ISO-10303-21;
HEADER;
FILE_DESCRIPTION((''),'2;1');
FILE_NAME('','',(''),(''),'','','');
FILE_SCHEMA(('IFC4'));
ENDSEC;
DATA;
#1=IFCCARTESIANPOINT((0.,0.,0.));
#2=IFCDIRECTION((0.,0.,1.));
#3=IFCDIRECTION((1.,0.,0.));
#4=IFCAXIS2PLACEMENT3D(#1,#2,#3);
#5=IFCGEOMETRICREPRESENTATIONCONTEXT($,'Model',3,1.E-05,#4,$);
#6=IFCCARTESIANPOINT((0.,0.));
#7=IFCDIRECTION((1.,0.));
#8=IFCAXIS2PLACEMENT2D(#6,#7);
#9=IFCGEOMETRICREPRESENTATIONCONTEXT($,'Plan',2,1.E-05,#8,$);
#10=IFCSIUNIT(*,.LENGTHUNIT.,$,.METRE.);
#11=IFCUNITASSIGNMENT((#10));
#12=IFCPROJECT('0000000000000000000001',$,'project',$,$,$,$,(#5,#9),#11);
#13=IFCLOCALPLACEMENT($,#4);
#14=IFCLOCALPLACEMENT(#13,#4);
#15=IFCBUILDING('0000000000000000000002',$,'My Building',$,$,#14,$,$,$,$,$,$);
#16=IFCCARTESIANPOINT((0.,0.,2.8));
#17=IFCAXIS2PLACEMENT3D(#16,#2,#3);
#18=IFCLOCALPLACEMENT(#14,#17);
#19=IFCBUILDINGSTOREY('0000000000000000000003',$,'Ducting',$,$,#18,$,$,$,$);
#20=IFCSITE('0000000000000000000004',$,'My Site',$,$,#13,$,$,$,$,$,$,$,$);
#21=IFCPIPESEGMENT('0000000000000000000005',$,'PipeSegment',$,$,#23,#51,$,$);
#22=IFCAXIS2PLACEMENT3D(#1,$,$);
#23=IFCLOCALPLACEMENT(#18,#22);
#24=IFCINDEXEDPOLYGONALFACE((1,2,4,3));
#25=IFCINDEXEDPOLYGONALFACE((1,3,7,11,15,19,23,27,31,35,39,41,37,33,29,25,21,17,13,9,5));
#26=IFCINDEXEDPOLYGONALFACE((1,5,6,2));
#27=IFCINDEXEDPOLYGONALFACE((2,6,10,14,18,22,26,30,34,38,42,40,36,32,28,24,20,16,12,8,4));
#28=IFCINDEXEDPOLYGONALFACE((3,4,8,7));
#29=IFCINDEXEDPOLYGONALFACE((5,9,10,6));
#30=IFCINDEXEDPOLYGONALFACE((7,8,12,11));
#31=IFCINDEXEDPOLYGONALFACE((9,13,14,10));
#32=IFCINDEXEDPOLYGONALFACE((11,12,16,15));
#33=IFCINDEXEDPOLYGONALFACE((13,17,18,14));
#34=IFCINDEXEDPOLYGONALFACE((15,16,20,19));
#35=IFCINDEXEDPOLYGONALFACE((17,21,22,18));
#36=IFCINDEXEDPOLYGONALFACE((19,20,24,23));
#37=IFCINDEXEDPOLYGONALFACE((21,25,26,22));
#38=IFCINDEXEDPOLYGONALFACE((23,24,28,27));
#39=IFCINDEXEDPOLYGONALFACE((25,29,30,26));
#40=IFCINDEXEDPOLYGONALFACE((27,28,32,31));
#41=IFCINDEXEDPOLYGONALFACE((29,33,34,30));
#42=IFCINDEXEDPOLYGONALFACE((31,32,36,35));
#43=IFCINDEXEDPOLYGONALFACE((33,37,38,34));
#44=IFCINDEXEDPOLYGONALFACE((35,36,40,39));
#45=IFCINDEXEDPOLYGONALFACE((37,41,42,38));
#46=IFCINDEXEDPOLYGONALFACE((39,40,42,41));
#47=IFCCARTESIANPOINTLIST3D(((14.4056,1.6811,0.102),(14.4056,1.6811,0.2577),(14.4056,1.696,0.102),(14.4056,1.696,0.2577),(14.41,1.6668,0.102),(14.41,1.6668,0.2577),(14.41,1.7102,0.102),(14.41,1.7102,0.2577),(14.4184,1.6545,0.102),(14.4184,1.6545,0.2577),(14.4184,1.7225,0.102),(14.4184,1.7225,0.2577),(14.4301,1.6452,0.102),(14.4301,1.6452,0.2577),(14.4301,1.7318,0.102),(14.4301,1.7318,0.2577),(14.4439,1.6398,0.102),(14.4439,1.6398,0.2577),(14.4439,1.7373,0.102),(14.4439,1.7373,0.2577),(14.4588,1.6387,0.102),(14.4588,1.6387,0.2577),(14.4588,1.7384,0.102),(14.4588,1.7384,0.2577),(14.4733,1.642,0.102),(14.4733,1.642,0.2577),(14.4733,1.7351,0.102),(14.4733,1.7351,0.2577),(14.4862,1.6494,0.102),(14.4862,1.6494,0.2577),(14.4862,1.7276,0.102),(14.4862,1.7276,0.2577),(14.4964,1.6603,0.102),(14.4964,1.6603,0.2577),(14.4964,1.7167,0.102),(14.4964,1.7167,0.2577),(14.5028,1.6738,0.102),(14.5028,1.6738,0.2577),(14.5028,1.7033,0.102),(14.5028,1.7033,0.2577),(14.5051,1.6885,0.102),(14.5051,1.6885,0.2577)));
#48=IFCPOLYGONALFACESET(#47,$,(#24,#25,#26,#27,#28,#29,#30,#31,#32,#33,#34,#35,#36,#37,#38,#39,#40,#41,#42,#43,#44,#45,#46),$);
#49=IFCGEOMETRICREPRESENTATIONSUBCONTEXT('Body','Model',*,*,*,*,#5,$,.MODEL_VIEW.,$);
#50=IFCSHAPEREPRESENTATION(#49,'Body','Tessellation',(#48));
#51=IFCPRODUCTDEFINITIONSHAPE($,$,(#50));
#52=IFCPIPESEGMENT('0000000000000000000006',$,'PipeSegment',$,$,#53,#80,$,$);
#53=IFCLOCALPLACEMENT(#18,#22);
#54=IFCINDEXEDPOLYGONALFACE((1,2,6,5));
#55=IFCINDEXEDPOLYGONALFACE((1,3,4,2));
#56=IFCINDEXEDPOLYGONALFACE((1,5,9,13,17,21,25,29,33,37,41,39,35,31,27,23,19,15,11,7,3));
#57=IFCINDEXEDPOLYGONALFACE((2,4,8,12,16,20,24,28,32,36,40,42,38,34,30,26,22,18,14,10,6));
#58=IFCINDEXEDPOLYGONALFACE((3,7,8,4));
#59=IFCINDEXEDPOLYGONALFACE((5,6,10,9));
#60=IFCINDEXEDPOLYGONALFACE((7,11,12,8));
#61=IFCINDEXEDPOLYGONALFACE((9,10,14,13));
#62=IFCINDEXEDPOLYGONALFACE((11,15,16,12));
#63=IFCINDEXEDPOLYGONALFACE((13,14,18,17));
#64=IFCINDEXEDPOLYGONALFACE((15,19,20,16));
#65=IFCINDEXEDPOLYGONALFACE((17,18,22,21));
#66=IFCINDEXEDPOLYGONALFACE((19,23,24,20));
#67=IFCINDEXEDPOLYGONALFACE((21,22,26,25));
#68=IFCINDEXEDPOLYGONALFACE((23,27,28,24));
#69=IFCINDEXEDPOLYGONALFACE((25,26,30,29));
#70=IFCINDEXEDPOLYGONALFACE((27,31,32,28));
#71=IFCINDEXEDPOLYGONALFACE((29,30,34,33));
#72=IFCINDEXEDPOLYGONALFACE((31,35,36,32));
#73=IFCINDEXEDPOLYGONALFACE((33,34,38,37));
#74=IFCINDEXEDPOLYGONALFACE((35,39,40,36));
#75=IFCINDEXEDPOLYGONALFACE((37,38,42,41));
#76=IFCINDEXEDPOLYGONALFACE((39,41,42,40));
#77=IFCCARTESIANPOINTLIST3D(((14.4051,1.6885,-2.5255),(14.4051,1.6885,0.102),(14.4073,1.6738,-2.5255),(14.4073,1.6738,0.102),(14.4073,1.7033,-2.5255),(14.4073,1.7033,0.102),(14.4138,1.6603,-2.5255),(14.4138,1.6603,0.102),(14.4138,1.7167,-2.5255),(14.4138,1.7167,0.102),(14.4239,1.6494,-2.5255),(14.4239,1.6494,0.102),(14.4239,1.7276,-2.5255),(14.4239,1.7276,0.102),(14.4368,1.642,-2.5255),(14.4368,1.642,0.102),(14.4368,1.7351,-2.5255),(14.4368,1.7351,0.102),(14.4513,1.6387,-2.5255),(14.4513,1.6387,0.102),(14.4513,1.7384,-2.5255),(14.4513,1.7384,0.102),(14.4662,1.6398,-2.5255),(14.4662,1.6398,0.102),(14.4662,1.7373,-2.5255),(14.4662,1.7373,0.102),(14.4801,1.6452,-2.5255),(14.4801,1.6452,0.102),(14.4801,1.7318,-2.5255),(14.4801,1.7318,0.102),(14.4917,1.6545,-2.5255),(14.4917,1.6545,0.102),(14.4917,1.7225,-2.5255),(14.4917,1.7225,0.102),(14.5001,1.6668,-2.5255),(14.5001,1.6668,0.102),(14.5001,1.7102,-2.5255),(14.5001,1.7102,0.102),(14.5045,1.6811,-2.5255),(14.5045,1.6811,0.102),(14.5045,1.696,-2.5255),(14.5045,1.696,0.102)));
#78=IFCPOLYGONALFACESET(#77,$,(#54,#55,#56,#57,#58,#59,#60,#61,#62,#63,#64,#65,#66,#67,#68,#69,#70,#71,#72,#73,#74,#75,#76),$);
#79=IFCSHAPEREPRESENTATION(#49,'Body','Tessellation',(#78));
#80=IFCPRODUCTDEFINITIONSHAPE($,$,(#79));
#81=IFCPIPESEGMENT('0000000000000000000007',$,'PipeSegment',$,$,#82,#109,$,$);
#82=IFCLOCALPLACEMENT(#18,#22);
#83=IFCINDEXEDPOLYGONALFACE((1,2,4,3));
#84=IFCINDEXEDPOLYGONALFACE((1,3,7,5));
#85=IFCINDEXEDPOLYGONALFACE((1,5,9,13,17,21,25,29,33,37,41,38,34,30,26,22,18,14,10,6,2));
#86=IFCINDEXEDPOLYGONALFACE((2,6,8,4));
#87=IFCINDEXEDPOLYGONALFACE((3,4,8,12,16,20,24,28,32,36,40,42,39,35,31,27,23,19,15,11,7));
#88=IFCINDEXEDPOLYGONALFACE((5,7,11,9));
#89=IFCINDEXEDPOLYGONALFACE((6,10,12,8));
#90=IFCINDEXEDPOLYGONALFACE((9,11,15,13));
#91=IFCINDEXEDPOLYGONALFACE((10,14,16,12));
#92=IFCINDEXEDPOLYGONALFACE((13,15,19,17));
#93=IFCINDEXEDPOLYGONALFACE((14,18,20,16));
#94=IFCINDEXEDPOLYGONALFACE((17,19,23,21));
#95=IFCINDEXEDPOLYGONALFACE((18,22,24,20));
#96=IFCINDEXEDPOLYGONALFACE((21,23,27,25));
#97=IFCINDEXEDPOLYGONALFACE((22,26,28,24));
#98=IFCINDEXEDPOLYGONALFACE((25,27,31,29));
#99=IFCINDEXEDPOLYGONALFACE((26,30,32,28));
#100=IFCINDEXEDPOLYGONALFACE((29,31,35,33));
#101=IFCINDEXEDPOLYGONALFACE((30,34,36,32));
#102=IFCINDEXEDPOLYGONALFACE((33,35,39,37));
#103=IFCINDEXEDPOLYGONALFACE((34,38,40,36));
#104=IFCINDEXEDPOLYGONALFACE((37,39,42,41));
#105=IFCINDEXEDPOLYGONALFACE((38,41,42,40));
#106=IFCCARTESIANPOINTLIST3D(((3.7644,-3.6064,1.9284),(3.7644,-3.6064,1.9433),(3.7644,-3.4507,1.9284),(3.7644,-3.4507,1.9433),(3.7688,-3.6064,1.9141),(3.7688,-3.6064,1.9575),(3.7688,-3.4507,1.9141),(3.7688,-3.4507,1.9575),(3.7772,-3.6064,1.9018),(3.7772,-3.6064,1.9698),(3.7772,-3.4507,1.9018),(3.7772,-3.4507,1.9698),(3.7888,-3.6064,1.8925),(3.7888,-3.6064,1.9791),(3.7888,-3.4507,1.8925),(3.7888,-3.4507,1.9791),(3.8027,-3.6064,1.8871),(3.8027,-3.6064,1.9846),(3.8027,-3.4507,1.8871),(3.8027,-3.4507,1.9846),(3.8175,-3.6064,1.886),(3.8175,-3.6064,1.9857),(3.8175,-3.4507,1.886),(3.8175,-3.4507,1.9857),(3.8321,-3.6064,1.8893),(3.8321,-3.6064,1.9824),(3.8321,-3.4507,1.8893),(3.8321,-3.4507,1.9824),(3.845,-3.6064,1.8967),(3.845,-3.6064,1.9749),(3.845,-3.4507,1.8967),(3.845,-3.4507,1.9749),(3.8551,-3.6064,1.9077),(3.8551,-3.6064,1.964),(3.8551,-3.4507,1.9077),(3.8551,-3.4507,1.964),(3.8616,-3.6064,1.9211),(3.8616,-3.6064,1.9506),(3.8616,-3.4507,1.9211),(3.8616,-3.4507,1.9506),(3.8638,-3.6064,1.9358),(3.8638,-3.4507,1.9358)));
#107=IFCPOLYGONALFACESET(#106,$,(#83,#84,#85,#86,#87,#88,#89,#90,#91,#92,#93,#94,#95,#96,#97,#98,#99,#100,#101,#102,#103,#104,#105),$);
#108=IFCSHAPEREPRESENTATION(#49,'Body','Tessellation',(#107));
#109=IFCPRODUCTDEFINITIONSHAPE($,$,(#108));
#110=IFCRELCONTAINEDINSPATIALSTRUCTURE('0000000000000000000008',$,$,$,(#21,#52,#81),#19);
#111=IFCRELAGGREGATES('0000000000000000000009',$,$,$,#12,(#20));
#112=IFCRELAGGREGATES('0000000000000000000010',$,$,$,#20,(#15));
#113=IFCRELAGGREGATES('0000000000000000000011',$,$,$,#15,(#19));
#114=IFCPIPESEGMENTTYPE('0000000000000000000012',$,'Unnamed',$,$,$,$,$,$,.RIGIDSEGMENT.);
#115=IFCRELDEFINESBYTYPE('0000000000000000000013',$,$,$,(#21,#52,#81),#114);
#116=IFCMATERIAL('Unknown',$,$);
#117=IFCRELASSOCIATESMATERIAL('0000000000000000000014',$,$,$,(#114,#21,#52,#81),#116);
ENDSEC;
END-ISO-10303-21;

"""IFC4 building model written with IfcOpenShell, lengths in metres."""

from ifc_helpers import new_model, si_unit, frame, origin_with_axes, origin_2d_with_axis, place, context, subcontext, project, spatial, circle, extrude, material, material_profile, profile_set, profile_usage, type_object, element, save


model = new_model("IFC4")

# Units and contexts
model_context = context("Model", 3, precision=1e-05, world=origin_with_axes())
plan_context = context("Plan", 2, precision=1e-05, world=origin_2d_with_axis())
body_context = subcontext(model_context, "Body", "Model", "MODEL_VIEW")
ifc_project = project(units=[si_unit("LENGTHUNIT", "METRE")], contexts=[model_context, plan_context])

# Site, building, storey
site_placement = place(None, origin_with_axes())
site = spatial("IfcSite", under=ifc_project, at=site_placement, Name="My Site")
building_placement = place(site_placement, origin_with_axes())
building = spatial("IfcBuilding", under=site, at=building_placement, Name="My Building")
storey_placement = place(building_placement, frame((0.0, 0.0, 2.8), z_axis=(0.0, 0.0, 1.0), x_axis=(1.0, 0.0, 0.0)))
storey = spatial("IfcBuildingStorey", under=building, at=storey_placement, Name="Ducting")

# Shared definitions
ifc_material = material(Name="Unknown")

# Pipe segments
ifc_material_profile_1 = material_profile(ifc_material, circle(Radius=0.05))
ifc_profile_set_1 = profile_set([ifc_material_profile_1])
pipe_segment_type = type_object("IfcPipeSegmentType", Name="Unnamed", PredefinedType="RIGIDSEGMENT", material=ifc_profile_set_1)
ifc_profile_usage_1 = profile_usage(ifc_profile_set_1, cardinal=5)
pipe_segment_1_placement = place(storey_placement, frame((14.4551, 1.6885, 0.2577), z_axis=(0.0, 0.0, -1.0), x_axis=(1.0, 0.0, 0.0)))
element("IfcPipeSegment", 1, at=pipe_segment_1_placement, inside=storey, type_object=pipe_segment_type, material=ifc_profile_usage_1, Name="PipeSegment", context=body_context, shape_type="SweptSolid", body=[
    extrude(circle(Radius=0.05), origin_with_axes(), (0.0, 0.0, 1.0), 0.1557),
])
ifc_profile_usage_2 = profile_usage(ifc_profile_set_1, cardinal=5)
pipe_segment_2_placement = place(storey_placement, frame((14.4551, 1.6885, 0.102), z_axis=(0.0, 0.0, -1.0), x_axis=(-1.0, 0.0, 0.0)))
element("IfcPipeSegment", 2, at=pipe_segment_2_placement, inside=storey, type_object=pipe_segment_type, material=ifc_profile_usage_2, Name="PipeSegment", context=body_context, shape_type="SweptSolid", body=[
    extrude(circle(Radius=0.05), origin_with_axes(), (0.0, 0.0, 1.0), 2.6274),
])
ifc_profile_usage_3 = profile_usage(ifc_profile_set_1, cardinal=5)
pipe_segment_3_placement = place(storey_placement, frame((3.8138, -3.4507, 1.9358), z_axis=(0.0, -1.0, 0.0), x_axis=(1.0, 0.0, 0.0)))
element("IfcPipeSegment", 3, at=pipe_segment_3_placement, inside=storey, type_object=pipe_segment_type, material=ifc_profile_usage_3, Name="PipeSegment", context=body_context, shape_type="SweptSolid", body=[
    extrude(circle(Radius=0.05), origin_with_axes(), (0.0, 0.0, 1.0), 0.1557),
])

save(model, "model.ifc")
